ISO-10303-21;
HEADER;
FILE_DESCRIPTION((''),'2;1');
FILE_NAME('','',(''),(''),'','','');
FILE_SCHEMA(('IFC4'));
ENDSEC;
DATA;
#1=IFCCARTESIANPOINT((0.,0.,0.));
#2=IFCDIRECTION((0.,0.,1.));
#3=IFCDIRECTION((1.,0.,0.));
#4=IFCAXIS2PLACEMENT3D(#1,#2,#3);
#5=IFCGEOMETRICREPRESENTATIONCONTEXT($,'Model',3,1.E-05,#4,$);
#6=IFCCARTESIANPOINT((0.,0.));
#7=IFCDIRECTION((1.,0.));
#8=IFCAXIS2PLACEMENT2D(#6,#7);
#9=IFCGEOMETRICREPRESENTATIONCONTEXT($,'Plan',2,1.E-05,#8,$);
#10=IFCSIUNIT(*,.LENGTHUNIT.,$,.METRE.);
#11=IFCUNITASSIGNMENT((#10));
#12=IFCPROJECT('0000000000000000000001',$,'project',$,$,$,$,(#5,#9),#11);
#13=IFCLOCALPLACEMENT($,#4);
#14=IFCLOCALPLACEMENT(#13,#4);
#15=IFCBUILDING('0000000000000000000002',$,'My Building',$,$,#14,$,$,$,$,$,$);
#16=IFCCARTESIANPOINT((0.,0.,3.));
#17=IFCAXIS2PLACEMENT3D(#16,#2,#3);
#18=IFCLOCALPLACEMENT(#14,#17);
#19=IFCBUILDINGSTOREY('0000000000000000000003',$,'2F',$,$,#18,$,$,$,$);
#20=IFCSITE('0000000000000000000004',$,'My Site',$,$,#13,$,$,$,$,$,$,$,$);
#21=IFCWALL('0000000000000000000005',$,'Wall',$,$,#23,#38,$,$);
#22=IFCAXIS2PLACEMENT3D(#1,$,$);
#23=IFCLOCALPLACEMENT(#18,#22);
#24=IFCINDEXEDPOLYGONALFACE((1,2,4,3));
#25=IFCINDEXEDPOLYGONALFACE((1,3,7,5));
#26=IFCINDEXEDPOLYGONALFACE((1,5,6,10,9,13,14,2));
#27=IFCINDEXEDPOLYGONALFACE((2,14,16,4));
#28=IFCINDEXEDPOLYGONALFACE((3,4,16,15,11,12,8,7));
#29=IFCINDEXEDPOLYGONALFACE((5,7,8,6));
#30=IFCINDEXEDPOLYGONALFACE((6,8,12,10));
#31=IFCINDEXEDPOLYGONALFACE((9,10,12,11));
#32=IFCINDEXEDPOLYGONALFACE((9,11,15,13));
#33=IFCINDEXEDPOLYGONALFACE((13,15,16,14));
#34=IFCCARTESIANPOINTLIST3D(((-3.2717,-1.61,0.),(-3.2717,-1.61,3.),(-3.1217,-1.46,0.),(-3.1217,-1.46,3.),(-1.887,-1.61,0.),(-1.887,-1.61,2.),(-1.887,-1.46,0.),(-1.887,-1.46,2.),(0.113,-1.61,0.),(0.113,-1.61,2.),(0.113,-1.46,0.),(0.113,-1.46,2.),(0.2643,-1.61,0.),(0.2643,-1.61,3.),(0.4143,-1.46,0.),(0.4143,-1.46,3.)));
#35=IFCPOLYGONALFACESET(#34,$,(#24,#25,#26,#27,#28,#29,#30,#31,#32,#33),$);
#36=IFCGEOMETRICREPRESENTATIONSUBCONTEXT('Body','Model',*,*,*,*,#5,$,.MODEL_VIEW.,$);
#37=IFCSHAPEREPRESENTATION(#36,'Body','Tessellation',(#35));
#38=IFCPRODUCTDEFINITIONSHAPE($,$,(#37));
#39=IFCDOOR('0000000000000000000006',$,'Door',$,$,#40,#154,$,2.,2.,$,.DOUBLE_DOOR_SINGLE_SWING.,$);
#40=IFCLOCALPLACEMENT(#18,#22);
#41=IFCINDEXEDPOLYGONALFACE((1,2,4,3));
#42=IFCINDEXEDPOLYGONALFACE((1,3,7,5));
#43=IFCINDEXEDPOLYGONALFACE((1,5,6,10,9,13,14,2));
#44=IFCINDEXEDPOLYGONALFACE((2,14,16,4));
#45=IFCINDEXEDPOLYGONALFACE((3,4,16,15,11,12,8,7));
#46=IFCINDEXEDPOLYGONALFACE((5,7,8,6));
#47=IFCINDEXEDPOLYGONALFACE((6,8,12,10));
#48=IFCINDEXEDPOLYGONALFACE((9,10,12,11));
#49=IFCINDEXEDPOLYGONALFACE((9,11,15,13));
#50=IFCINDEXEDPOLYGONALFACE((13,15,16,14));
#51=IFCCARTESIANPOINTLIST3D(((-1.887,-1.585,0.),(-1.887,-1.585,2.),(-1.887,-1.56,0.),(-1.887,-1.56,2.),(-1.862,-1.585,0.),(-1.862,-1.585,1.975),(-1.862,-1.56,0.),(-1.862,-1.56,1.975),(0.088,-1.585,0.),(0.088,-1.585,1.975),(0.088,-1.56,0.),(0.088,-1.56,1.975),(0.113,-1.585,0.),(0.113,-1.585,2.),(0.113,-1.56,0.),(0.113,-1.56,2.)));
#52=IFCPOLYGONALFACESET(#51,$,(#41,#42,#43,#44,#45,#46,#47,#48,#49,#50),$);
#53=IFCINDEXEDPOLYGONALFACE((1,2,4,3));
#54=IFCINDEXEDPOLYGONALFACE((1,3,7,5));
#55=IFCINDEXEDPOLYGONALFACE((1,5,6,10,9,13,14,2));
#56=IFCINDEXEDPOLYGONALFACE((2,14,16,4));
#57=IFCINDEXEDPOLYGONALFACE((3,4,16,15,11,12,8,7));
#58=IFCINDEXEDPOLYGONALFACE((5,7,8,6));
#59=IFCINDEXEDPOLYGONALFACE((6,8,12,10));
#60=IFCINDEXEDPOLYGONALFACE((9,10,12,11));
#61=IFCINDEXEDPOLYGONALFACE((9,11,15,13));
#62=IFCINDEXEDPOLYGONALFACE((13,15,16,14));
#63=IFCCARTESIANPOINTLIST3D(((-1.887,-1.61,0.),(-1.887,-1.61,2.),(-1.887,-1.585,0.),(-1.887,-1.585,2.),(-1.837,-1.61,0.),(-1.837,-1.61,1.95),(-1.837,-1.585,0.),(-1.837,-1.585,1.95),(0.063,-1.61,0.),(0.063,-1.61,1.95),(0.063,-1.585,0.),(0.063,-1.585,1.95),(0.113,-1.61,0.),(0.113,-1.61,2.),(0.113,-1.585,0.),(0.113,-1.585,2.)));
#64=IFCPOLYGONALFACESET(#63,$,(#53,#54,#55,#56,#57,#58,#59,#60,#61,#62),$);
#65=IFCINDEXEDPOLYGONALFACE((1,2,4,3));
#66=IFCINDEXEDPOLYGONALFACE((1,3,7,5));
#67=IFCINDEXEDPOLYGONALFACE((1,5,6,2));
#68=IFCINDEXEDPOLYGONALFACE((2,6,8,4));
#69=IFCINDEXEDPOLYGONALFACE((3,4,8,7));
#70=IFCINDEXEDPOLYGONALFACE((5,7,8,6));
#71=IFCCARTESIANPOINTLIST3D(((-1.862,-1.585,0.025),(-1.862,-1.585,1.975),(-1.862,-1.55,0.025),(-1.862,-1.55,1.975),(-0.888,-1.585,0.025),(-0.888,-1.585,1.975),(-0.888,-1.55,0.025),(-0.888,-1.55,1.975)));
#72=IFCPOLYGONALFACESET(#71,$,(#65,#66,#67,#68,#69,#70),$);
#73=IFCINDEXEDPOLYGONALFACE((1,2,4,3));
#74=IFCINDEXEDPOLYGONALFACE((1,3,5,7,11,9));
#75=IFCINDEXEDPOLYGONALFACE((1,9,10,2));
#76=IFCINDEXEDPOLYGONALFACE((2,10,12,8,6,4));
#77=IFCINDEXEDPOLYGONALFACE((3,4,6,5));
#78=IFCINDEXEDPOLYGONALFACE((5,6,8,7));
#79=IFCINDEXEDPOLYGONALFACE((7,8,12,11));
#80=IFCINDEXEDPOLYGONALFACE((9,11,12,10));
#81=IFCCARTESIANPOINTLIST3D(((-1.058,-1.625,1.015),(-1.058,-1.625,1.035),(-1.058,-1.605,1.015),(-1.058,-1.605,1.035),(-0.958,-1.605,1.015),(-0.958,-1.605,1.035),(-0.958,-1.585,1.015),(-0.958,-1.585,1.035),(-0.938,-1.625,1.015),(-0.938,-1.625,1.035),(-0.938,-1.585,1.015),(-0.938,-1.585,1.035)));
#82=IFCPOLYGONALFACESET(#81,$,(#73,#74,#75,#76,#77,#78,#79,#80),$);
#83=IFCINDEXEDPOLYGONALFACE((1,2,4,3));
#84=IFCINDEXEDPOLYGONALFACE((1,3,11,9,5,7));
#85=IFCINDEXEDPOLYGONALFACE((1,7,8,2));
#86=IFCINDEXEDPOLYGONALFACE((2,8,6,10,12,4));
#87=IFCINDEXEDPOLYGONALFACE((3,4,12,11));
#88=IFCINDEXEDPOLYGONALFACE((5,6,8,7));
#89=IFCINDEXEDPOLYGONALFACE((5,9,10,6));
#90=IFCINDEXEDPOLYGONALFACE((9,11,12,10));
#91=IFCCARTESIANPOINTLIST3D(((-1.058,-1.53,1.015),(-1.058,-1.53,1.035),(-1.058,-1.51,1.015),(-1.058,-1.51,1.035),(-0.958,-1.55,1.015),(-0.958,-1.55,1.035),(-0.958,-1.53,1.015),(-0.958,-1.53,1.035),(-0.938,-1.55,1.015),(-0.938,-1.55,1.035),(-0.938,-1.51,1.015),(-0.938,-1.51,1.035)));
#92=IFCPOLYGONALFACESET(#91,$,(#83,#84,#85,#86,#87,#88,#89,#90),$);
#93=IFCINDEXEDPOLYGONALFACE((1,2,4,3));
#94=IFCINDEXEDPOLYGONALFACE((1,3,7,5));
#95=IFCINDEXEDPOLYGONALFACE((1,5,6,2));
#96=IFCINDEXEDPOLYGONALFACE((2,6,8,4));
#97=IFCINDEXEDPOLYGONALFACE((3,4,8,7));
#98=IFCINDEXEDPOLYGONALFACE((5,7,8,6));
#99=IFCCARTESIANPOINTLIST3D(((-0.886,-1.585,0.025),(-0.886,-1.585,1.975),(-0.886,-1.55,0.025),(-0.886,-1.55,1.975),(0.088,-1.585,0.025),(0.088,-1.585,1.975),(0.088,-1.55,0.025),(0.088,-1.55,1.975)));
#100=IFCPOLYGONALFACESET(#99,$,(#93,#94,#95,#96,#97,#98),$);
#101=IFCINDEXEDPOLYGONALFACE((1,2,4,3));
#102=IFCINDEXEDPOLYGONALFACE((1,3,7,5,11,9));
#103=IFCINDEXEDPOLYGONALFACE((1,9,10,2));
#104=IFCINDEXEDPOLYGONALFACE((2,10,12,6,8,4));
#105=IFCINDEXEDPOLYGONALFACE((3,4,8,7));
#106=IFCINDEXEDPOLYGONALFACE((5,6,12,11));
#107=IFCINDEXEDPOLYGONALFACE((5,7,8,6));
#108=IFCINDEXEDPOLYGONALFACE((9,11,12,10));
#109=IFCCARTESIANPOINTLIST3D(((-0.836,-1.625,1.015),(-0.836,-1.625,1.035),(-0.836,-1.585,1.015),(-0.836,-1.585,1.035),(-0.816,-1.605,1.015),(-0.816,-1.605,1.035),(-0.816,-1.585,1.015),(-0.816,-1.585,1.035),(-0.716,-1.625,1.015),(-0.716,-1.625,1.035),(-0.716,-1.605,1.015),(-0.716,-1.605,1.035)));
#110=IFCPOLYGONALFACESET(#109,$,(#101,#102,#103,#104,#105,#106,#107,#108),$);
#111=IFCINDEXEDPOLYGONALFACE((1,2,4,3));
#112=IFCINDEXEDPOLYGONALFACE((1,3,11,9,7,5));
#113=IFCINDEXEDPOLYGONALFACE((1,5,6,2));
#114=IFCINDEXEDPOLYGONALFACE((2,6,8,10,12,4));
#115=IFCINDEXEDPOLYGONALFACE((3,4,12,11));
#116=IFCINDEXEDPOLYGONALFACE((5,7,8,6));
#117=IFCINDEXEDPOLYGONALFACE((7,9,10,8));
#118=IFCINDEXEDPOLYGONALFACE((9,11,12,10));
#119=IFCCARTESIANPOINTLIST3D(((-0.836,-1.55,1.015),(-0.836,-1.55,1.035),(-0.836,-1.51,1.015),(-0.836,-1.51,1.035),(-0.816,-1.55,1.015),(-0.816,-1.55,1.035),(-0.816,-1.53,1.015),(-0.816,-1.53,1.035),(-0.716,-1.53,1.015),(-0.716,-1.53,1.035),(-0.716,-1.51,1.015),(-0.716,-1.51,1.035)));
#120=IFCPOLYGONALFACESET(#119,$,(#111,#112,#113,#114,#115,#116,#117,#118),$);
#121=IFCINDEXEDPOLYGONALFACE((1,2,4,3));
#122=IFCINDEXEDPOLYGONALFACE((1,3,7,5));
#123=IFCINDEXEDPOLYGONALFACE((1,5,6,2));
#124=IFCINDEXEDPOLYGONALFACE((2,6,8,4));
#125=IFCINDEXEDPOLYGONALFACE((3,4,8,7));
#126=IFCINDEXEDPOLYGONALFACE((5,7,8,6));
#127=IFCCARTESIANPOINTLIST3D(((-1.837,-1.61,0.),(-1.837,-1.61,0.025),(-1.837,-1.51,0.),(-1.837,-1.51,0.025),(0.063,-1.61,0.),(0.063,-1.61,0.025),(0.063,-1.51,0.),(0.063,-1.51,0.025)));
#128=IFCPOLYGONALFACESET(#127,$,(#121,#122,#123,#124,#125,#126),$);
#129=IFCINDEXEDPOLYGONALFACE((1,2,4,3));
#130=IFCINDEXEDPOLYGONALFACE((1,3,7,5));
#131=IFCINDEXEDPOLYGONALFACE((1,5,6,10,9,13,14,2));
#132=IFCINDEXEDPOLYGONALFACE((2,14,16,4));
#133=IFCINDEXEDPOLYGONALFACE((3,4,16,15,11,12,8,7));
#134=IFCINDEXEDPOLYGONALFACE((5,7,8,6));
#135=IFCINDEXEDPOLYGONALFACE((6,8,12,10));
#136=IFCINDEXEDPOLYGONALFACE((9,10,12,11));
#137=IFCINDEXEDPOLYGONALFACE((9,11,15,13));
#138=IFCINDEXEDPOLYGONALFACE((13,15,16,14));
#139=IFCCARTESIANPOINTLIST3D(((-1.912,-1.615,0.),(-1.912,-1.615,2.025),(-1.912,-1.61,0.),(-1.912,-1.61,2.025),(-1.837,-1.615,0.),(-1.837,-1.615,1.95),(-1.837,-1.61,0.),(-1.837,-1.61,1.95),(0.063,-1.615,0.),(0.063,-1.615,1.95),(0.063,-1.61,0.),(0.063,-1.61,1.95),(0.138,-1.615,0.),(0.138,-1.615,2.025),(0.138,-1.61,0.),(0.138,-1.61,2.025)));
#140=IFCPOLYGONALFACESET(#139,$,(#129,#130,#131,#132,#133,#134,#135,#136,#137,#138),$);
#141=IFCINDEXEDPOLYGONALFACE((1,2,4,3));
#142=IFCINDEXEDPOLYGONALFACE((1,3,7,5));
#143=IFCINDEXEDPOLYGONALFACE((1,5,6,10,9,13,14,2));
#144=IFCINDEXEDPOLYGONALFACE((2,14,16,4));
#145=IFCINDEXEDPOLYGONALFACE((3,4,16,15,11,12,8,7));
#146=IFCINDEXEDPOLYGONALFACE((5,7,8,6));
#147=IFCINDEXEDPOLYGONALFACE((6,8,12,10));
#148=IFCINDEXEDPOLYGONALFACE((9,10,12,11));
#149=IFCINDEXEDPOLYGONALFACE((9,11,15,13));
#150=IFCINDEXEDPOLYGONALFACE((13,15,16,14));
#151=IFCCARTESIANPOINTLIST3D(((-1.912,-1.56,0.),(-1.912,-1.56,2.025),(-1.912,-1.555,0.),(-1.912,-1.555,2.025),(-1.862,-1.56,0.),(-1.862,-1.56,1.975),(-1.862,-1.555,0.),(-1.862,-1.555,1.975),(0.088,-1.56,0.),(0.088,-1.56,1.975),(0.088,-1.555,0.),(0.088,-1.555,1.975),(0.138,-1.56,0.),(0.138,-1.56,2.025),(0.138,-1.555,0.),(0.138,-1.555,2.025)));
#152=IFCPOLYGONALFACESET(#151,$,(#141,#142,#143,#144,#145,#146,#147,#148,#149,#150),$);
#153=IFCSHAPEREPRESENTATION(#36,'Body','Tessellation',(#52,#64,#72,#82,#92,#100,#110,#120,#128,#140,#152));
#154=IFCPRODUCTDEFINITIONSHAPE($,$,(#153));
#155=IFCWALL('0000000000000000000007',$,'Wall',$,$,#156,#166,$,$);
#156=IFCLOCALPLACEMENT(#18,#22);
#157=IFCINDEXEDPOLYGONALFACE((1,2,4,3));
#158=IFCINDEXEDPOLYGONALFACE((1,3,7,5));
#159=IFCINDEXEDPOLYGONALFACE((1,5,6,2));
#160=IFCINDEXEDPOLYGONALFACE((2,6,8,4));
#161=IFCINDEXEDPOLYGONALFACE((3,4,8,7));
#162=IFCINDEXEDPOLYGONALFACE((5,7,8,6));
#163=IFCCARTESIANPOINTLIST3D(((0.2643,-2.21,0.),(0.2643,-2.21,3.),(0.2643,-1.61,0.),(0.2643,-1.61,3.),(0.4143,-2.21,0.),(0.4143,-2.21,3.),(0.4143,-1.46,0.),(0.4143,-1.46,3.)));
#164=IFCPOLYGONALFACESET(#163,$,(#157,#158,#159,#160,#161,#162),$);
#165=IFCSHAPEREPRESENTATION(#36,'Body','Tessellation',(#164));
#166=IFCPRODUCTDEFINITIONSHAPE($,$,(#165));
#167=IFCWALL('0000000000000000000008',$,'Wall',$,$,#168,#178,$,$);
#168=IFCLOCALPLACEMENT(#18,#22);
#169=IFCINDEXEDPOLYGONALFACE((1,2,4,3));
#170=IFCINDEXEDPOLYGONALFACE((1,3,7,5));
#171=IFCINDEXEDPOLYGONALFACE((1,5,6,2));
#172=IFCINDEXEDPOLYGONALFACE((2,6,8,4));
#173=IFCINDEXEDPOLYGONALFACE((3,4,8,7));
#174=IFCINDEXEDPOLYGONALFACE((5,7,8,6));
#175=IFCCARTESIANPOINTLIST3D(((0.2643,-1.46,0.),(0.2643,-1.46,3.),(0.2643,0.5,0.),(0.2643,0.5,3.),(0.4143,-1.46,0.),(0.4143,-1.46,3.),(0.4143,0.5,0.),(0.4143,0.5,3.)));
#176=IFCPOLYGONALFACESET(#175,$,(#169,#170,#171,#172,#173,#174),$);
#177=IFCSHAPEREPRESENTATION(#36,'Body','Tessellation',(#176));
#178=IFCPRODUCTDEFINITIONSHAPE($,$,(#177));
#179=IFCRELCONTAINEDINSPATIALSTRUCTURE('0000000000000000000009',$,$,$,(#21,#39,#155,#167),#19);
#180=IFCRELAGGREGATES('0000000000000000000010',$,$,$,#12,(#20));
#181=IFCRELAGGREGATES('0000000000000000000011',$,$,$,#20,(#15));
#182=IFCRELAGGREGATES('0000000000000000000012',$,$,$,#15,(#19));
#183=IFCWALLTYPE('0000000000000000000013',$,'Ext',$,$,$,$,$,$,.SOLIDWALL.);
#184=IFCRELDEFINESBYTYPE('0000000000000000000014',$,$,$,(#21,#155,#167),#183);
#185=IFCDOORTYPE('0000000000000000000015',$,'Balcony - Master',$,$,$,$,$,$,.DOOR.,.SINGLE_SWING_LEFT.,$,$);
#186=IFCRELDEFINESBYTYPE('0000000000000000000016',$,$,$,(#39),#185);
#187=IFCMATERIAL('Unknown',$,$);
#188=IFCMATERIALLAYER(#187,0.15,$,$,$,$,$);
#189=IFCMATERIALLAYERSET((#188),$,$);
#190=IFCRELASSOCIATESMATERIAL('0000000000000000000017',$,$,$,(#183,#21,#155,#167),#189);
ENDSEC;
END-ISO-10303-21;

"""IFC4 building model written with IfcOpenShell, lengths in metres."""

from ifc_helpers import new_model, entity, si_unit, frame, origin_with_axes, origin_2d_with_axis, place, context, subcontext, project, spatial, line, indexed_curve, outline, extrude, shape, source, transform, mapped, material, layer, layer_set, layer_usage, type_object, type_shapes, element, fill, save


model = new_model("IFC4")

# Units and contexts
model_context = context("Model", 3, precision=1e-05, world=origin_with_axes())
plan_context = context("Plan", 2, precision=1e-05, world=origin_2d_with_axis())
body_context_1 = subcontext(model_context, "Body", "Model", "MODEL_VIEW")
body_context_2 = subcontext(plan_context, "Body", "Plan", "PLAN_VIEW")
ifc_project = project(units=[si_unit("LENGTHUNIT", "METRE")], contexts=[model_context, plan_context])

# Site, building, storey
site_placement = place(None, origin_with_axes())
site = spatial("IfcSite", under=ifc_project, at=site_placement, Name="My Site")
building_placement = place(site_placement, origin_with_axes())
building = spatial("IfcBuilding", under=site, at=building_placement, Name="My Building")
storey_placement = place(building_placement, frame((0.0, 0.0, 3.0), z_axis=(0.0, 0.0, 1.0), x_axis=(1.0, 0.0, 0.0)))
storey = spatial("IfcBuildingStorey", under=building, at=storey_placement, Name="2F")

# Shared definitions
ifc_material = material(Name="Unknown")

# Shared definitions
ifc_layer_1 = layer(ifc_material, 0.15)
ifc_layer_set_1 = layer_set([ifc_layer_1])
wall_type_1 = type_object("IfcWallType", Name="Ext", PredefinedType="SOLIDWALL", material=ifc_layer_set_1)

# Wall, opening, door
ifc_layer_usage_1 = layer_usage(ifc_layer_set_1, "AXIS2", "POSITIVE", 0.0)
wall_1_placement = place(storey_placement, frame((-3.2717, -1.61, 0.0), z_axis=(0.0, 0.0, 1.0), x_axis=(1.0, 0.0, 0.0)))
wall_1 = element("IfcWall", 1, at=wall_1_placement, inside=storey, type_object=wall_type_1, material=ifc_layer_usage_1, Name="Wall", context=body_context_1, shape_type="SweptSolid", body=[
    extrude(outline(indexed_curve([(0.0, 0.0), (0.15, 0.15), (3.686, 0.15), (3.536, 0.0)], segments=[line(1, 2, 3, 4, 1)])), origin_with_axes(), (0.0, 0.0, 1.0), 3.0),
])
shared_shape_1 = source(origin_with_axes(), body_context_1, "Body", "SweptSolid", [
    extrude(outline(indexed_curve([(0.0, 0.0), (2.0, 0.0), (2.0, 2.0), (0.0, 2.0)], segments=[line(1, 2, 3, 4, 1)])), frame((0.0, -0.6, 0.0), z_axis=(0.0, -1.0, 0.0), x_axis=(1.0, 0.0, 0.0)), (0.0, 0.0, -1.0), 1.2),
])
opening_1_placement = place(wall_1_placement, frame((1.3847, 0.0, 0.0), z_axis=(0.0, 0.0, 1.0), x_axis=(1.0, 0.0, 0.0)))
opening_1 = element("IfcOpeningElement", 2, at=opening_1_placement, cuts=wall_1, PredefinedType="OPENING", context=body_context_1, shape_type="MappedRepresentation", body=[
    mapped(shared_shape_1, transform((0.0, 0.0, 0.0), x_axis=(1.0, 0.0, 0.0), y_axis=(0.0, 1.0, 0.0), z_axis=(0.0, 0.0, 1.0), scale=1.0)),
])
door_type_1 = type_object("IfcDoorType", Name="Balcony - Master", OperationType="SINGLE_SWING_LEFT", PredefinedType="DOOR")
shared_shape_2 = source(origin_with_axes(), body_context_1, "Body", "SweptSolid", [
    extrude(outline(indexed_curve([(0.0, 0.0), (0.0, 2.0), (2.0, 2.0), (2.0, 0.0), (1.975, 0.0), (1.975, 1.975), (0.025, 1.975), (0.025, 0.0)], segments=[line(1, 2, 3, 4, 5, 6, 7, 8, 1)])), frame((0.0, 0.025, 0.0), z_axis=(0.0, -1.0, 0.0), x_axis=(1.0, 0.0, 0.0)), (0.0, 0.0, -1.0), 0.025),
    extrude(outline(indexed_curve([(0.05, 0.0), (0.05, 1.95), (1.95, 1.95), (1.95, 0.0), (2.0, 0.0), (2.0, 2.0), (0.0, 2.0), (0.0, 0.0), (0.05, 0.0)])), frame((0.0, 0.0, 0.0), z_axis=(0.0, -1.0, 0.0), x_axis=(1.0, 0.0, 0.0)), (0.0, 0.0, -1.0), 0.025),
    extrude(outline(indexed_curve([(0.0, 0.0), (0.974, 0.0), (0.974, 0.035), (0.0, 0.035)], segments=[line(1, 2, 3, 4, 1)])), frame((0.025, 0.025, 0.025), z_axis=(0.0, 0.0, 1.0), x_axis=(1.0, 0.0, 0.0)), (0.0, 0.0, 1.0), 1.95),
    extrude(outline(indexed_curve([(0.0, 0.0), (0.0, -0.04), (-0.12, -0.04), (-0.12, -0.02), (-0.02, -0.02), (-0.02, 0.0)], segments=[line(1, 2, 3, 4, 5, 6, 1)])), frame((0.949, 0.025, 1.015), z_axis=(0.0, 0.0, 1.0), x_axis=(1.0, 0.0, 0.0)), (0.0, 0.0, 1.0), 0.02),
    extrude(outline(indexed_curve([(0.0, 0.0), (0.0, 0.04), (-0.12, 0.04), (-0.12, 0.02), (-0.02, 0.02), (-0.02, 0.0)], segments=[line(1, 2, 3, 4, 5, 6, 1)])), frame((0.949, 0.06, 1.015), z_axis=(0.0, 0.0, 1.0), x_axis=(1.0, 0.0, 0.0)), (0.0, 0.0, 1.0), 0.02),
    extrude(outline(indexed_curve([(0.0, 0.0), (-0.974, 0.0), (-0.974, 0.035), (0.0, 0.035)], segments=[line(1, 2, 3, 4, 1)])), frame((1.975, 0.025, 0.025), z_axis=(0.0, 0.0, 1.0), x_axis=(1.0, 0.0, 0.0)), (0.0, 0.0, 1.0), 1.95),
    extrude(outline(indexed_curve([(0.0, 0.0), (0.0, -0.04), (0.12, -0.04), (0.12, -0.02), (0.02, -0.02), (0.02, 0.0)], segments=[line(1, 2, 3, 4, 5, 6, 1)])), frame((1.051, 0.025, 1.015), z_axis=(0.0, 0.0, 1.0), x_axis=(1.0, 0.0, 0.0)), (0.0, 0.0, 1.0), 0.02),
    extrude(outline(indexed_curve([(0.0, 0.0), (0.0, 0.04), (0.12, 0.04), (0.12, 0.02), (0.02, 0.02), (0.02, 0.0)], segments=[line(1, 2, 3, 4, 5, 6, 1)])), frame((1.051, 0.06, 1.015), z_axis=(0.0, 0.0, 1.0), x_axis=(1.0, 0.0, 0.0)), (0.0, 0.0, 1.0), 0.02),
    extrude(outline(indexed_curve([(0.0, 0.1), (1.9, 0.1), (1.9, 0.0), (0.0, 0.0), (0.0, 0.1)])), frame((0.05, 0.0, 0.0), z_axis=(0.0, 0.0, 1.0), x_axis=(1.0, 0.0, 0.0)), (0.0, 0.0, 1.0), 0.025),
    extrude(outline(indexed_curve([(0.075, 0.0), (0.075, 1.95), (1.975, 1.95), (1.975, 0.0), (2.05, 0.0), (2.05, 2.025), (0.0, 2.025), (0.0, 0.0), (0.075, 0.0)])), frame((-0.025, -0.005, 0.0), z_axis=(0.0, -1.0, 0.0), x_axis=(1.0, 0.0, 0.0)), (0.0, 0.0, -1.0), 0.005),
    extrude(outline(indexed_curve([(0.0, 0.0), (0.0, 2.025), (2.05, 2.025), (2.05, 0.0), (2.0, 0.0), (2.0, 1.975), (0.05, 1.975), (0.05, 0.0)], segments=[line(1, 2, 3, 4, 5, 6, 7, 8, 1)])), frame((-0.025, 0.05, 0.0), z_axis=(0.0, -1.0, 0.0), x_axis=(1.0, 0.0, 0.0)), (0.0, 0.0, -1.0), 0.005),
])
shared_shape_3 = source(origin_with_axes(), body_context_2, "Body", "Curve2D", [
    entity("IfcIndexedPolyCurve", entity("IfcCartesianPointList2D", [[0.0, 0.0], [0.0, 0.05], [0.025, 0.05], [0.025, 0.025], [0.05, 0.025], [0.05, 0.0]]), [entity("IfcLineIndex", [1, 2, 3, 4, 5, 6, 1])]),
    entity("IfcIndexedPolyCurve", entity("IfcCartesianPointList2D", [[2.0, 0.0], [2.0, 0.05], [1.975, 0.05], [1.975, 0.025], [1.95, 0.025], [1.95, 0.0]]), [entity("IfcLineIndex", [1, 2, 3, 4, 5, 6, 1])]),
    entity("IfcTrimmedCurve", entity("IfcEllipse", entity("IfcAxis2Placement2D", entity("IfcCartesianPoint", [0.06, 0.05]), entity("IfcDirection", [1.0, 0.0])), 0.94, 0.975), [entity("IfcCartesianPoint", [1.0, 0.05])], [entity("IfcCartesianPoint", [0.06, 1.025])], True, "CARTESIAN"),
    entity("IfcIndexedPolyCurve", entity("IfcCartesianPointList2D", [[0.025, 0.05], [0.06, 0.05], [0.06, 1.025], [0.025, 1.025]]), [entity("IfcLineIndex", [1, 2, 3, 4, 1])]),
    entity("IfcTrimmedCurve", entity("IfcEllipse", entity("IfcAxis2Placement2D", entity("IfcCartesianPoint", [1.94, 0.05]), entity("IfcDirection", [1.0, 0.0])), 0.94, 0.975), [entity("IfcCartesianPoint", [1.94, 1.025])], [entity("IfcCartesianPoint", [1.0, 0.05])], True, "CARTESIAN"),
    entity("IfcIndexedPolyCurve", entity("IfcCartesianPointList2D", [[1.975, 0.05], [1.94, 0.05], [1.94, 1.025], [1.975, 1.025]]), [entity("IfcLineIndex", [1, 2, 3, 4, 1])]),
])
type_shapes(door_type_1, [shared_shape_2, shared_shape_3])
door_1_placement = place(opening_1_placement, frame((0.0, 0.0, 0.0), z_axis=(0.0, 0.0, 1.0), x_axis=(1.0, 0.0, 0.0)))
door_1 = element("IfcDoor", 3, at=door_1_placement, inside=storey, type_object=door_type_1, Name="Door", OperationType="DOUBLE_DOOR_SINGLE_SWING", OverallHeight=2.0, OverallWidth=2.0, shapes=[
    shape(body_context_1, "Body", "MappedRepresentation", [mapped(shared_shape_2, transform((0.0, 0.0, 0.0), x_axis=(1.0, 0.0, 0.0), y_axis=(0.0, 1.0, 0.0), z_axis=(0.0, 0.0, 1.0), scale=1.0))]),
    shape(body_context_2, "Body", "MappedRepresentation", [mapped(shared_shape_3, transform((0.0, 0.0, 0.0), x_axis=(1.0, 0.0, 0.0), y_axis=(0.0, 1.0, 0.0), z_axis=(0.0, 0.0, 1.0), scale=1.0))]),
])
fill(opening_1, door_1)

# Walls
ifc_layer_usage_2 = layer_usage(ifc_layer_set_1, "AXIS2", "POSITIVE", 0.0)
wall_2_placement = place(storey_placement, frame((0.2643, -1.61, 0.0), z_axis=(0.0, 0.0, 1.0), x_axis=(0.0, -1.0, 0.0)))
element("IfcWall", 4, at=wall_2_placement, inside=storey, type_object=wall_type_1, material=ifc_layer_usage_2, Name="Wall", context=body_context_1, shape_type="SweptSolid", body=[
    extrude(outline(indexed_curve([(0.0, 0.0), (-0.15, 0.15), (0.6, 0.15), (0.6, 0.0)], segments=[line(1, 2, 3, 4, 1)])), origin_with_axes(), (0.0, 0.0, 1.0), 3.0),
])
ifc_layer_usage_3 = layer_usage(ifc_layer_set_1, "AXIS2", "POSITIVE", 0.0)
wall_3_placement = place(storey_placement, frame((0.4143, -1.46, 0.0), z_axis=(0.0, 0.0, 1.0), x_axis=(0.0, 1.0, 0.0)))
element("IfcWall", 5, at=wall_3_placement, inside=storey, type_object=wall_type_1, material=ifc_layer_usage_3, Name="Wall", context=body_context_1, shape_type="SweptSolid", body=[
    extrude(outline(indexed_curve([(0.0, 0.0), (0.0, 0.15), (1.96, 0.15), (1.96, 0.0)], segments=[line(1, 2, 3, 4, 1)])), origin_with_axes(), (0.0, 0.0, 1.0), 3.0),
])

save(model, "model.ifc")
